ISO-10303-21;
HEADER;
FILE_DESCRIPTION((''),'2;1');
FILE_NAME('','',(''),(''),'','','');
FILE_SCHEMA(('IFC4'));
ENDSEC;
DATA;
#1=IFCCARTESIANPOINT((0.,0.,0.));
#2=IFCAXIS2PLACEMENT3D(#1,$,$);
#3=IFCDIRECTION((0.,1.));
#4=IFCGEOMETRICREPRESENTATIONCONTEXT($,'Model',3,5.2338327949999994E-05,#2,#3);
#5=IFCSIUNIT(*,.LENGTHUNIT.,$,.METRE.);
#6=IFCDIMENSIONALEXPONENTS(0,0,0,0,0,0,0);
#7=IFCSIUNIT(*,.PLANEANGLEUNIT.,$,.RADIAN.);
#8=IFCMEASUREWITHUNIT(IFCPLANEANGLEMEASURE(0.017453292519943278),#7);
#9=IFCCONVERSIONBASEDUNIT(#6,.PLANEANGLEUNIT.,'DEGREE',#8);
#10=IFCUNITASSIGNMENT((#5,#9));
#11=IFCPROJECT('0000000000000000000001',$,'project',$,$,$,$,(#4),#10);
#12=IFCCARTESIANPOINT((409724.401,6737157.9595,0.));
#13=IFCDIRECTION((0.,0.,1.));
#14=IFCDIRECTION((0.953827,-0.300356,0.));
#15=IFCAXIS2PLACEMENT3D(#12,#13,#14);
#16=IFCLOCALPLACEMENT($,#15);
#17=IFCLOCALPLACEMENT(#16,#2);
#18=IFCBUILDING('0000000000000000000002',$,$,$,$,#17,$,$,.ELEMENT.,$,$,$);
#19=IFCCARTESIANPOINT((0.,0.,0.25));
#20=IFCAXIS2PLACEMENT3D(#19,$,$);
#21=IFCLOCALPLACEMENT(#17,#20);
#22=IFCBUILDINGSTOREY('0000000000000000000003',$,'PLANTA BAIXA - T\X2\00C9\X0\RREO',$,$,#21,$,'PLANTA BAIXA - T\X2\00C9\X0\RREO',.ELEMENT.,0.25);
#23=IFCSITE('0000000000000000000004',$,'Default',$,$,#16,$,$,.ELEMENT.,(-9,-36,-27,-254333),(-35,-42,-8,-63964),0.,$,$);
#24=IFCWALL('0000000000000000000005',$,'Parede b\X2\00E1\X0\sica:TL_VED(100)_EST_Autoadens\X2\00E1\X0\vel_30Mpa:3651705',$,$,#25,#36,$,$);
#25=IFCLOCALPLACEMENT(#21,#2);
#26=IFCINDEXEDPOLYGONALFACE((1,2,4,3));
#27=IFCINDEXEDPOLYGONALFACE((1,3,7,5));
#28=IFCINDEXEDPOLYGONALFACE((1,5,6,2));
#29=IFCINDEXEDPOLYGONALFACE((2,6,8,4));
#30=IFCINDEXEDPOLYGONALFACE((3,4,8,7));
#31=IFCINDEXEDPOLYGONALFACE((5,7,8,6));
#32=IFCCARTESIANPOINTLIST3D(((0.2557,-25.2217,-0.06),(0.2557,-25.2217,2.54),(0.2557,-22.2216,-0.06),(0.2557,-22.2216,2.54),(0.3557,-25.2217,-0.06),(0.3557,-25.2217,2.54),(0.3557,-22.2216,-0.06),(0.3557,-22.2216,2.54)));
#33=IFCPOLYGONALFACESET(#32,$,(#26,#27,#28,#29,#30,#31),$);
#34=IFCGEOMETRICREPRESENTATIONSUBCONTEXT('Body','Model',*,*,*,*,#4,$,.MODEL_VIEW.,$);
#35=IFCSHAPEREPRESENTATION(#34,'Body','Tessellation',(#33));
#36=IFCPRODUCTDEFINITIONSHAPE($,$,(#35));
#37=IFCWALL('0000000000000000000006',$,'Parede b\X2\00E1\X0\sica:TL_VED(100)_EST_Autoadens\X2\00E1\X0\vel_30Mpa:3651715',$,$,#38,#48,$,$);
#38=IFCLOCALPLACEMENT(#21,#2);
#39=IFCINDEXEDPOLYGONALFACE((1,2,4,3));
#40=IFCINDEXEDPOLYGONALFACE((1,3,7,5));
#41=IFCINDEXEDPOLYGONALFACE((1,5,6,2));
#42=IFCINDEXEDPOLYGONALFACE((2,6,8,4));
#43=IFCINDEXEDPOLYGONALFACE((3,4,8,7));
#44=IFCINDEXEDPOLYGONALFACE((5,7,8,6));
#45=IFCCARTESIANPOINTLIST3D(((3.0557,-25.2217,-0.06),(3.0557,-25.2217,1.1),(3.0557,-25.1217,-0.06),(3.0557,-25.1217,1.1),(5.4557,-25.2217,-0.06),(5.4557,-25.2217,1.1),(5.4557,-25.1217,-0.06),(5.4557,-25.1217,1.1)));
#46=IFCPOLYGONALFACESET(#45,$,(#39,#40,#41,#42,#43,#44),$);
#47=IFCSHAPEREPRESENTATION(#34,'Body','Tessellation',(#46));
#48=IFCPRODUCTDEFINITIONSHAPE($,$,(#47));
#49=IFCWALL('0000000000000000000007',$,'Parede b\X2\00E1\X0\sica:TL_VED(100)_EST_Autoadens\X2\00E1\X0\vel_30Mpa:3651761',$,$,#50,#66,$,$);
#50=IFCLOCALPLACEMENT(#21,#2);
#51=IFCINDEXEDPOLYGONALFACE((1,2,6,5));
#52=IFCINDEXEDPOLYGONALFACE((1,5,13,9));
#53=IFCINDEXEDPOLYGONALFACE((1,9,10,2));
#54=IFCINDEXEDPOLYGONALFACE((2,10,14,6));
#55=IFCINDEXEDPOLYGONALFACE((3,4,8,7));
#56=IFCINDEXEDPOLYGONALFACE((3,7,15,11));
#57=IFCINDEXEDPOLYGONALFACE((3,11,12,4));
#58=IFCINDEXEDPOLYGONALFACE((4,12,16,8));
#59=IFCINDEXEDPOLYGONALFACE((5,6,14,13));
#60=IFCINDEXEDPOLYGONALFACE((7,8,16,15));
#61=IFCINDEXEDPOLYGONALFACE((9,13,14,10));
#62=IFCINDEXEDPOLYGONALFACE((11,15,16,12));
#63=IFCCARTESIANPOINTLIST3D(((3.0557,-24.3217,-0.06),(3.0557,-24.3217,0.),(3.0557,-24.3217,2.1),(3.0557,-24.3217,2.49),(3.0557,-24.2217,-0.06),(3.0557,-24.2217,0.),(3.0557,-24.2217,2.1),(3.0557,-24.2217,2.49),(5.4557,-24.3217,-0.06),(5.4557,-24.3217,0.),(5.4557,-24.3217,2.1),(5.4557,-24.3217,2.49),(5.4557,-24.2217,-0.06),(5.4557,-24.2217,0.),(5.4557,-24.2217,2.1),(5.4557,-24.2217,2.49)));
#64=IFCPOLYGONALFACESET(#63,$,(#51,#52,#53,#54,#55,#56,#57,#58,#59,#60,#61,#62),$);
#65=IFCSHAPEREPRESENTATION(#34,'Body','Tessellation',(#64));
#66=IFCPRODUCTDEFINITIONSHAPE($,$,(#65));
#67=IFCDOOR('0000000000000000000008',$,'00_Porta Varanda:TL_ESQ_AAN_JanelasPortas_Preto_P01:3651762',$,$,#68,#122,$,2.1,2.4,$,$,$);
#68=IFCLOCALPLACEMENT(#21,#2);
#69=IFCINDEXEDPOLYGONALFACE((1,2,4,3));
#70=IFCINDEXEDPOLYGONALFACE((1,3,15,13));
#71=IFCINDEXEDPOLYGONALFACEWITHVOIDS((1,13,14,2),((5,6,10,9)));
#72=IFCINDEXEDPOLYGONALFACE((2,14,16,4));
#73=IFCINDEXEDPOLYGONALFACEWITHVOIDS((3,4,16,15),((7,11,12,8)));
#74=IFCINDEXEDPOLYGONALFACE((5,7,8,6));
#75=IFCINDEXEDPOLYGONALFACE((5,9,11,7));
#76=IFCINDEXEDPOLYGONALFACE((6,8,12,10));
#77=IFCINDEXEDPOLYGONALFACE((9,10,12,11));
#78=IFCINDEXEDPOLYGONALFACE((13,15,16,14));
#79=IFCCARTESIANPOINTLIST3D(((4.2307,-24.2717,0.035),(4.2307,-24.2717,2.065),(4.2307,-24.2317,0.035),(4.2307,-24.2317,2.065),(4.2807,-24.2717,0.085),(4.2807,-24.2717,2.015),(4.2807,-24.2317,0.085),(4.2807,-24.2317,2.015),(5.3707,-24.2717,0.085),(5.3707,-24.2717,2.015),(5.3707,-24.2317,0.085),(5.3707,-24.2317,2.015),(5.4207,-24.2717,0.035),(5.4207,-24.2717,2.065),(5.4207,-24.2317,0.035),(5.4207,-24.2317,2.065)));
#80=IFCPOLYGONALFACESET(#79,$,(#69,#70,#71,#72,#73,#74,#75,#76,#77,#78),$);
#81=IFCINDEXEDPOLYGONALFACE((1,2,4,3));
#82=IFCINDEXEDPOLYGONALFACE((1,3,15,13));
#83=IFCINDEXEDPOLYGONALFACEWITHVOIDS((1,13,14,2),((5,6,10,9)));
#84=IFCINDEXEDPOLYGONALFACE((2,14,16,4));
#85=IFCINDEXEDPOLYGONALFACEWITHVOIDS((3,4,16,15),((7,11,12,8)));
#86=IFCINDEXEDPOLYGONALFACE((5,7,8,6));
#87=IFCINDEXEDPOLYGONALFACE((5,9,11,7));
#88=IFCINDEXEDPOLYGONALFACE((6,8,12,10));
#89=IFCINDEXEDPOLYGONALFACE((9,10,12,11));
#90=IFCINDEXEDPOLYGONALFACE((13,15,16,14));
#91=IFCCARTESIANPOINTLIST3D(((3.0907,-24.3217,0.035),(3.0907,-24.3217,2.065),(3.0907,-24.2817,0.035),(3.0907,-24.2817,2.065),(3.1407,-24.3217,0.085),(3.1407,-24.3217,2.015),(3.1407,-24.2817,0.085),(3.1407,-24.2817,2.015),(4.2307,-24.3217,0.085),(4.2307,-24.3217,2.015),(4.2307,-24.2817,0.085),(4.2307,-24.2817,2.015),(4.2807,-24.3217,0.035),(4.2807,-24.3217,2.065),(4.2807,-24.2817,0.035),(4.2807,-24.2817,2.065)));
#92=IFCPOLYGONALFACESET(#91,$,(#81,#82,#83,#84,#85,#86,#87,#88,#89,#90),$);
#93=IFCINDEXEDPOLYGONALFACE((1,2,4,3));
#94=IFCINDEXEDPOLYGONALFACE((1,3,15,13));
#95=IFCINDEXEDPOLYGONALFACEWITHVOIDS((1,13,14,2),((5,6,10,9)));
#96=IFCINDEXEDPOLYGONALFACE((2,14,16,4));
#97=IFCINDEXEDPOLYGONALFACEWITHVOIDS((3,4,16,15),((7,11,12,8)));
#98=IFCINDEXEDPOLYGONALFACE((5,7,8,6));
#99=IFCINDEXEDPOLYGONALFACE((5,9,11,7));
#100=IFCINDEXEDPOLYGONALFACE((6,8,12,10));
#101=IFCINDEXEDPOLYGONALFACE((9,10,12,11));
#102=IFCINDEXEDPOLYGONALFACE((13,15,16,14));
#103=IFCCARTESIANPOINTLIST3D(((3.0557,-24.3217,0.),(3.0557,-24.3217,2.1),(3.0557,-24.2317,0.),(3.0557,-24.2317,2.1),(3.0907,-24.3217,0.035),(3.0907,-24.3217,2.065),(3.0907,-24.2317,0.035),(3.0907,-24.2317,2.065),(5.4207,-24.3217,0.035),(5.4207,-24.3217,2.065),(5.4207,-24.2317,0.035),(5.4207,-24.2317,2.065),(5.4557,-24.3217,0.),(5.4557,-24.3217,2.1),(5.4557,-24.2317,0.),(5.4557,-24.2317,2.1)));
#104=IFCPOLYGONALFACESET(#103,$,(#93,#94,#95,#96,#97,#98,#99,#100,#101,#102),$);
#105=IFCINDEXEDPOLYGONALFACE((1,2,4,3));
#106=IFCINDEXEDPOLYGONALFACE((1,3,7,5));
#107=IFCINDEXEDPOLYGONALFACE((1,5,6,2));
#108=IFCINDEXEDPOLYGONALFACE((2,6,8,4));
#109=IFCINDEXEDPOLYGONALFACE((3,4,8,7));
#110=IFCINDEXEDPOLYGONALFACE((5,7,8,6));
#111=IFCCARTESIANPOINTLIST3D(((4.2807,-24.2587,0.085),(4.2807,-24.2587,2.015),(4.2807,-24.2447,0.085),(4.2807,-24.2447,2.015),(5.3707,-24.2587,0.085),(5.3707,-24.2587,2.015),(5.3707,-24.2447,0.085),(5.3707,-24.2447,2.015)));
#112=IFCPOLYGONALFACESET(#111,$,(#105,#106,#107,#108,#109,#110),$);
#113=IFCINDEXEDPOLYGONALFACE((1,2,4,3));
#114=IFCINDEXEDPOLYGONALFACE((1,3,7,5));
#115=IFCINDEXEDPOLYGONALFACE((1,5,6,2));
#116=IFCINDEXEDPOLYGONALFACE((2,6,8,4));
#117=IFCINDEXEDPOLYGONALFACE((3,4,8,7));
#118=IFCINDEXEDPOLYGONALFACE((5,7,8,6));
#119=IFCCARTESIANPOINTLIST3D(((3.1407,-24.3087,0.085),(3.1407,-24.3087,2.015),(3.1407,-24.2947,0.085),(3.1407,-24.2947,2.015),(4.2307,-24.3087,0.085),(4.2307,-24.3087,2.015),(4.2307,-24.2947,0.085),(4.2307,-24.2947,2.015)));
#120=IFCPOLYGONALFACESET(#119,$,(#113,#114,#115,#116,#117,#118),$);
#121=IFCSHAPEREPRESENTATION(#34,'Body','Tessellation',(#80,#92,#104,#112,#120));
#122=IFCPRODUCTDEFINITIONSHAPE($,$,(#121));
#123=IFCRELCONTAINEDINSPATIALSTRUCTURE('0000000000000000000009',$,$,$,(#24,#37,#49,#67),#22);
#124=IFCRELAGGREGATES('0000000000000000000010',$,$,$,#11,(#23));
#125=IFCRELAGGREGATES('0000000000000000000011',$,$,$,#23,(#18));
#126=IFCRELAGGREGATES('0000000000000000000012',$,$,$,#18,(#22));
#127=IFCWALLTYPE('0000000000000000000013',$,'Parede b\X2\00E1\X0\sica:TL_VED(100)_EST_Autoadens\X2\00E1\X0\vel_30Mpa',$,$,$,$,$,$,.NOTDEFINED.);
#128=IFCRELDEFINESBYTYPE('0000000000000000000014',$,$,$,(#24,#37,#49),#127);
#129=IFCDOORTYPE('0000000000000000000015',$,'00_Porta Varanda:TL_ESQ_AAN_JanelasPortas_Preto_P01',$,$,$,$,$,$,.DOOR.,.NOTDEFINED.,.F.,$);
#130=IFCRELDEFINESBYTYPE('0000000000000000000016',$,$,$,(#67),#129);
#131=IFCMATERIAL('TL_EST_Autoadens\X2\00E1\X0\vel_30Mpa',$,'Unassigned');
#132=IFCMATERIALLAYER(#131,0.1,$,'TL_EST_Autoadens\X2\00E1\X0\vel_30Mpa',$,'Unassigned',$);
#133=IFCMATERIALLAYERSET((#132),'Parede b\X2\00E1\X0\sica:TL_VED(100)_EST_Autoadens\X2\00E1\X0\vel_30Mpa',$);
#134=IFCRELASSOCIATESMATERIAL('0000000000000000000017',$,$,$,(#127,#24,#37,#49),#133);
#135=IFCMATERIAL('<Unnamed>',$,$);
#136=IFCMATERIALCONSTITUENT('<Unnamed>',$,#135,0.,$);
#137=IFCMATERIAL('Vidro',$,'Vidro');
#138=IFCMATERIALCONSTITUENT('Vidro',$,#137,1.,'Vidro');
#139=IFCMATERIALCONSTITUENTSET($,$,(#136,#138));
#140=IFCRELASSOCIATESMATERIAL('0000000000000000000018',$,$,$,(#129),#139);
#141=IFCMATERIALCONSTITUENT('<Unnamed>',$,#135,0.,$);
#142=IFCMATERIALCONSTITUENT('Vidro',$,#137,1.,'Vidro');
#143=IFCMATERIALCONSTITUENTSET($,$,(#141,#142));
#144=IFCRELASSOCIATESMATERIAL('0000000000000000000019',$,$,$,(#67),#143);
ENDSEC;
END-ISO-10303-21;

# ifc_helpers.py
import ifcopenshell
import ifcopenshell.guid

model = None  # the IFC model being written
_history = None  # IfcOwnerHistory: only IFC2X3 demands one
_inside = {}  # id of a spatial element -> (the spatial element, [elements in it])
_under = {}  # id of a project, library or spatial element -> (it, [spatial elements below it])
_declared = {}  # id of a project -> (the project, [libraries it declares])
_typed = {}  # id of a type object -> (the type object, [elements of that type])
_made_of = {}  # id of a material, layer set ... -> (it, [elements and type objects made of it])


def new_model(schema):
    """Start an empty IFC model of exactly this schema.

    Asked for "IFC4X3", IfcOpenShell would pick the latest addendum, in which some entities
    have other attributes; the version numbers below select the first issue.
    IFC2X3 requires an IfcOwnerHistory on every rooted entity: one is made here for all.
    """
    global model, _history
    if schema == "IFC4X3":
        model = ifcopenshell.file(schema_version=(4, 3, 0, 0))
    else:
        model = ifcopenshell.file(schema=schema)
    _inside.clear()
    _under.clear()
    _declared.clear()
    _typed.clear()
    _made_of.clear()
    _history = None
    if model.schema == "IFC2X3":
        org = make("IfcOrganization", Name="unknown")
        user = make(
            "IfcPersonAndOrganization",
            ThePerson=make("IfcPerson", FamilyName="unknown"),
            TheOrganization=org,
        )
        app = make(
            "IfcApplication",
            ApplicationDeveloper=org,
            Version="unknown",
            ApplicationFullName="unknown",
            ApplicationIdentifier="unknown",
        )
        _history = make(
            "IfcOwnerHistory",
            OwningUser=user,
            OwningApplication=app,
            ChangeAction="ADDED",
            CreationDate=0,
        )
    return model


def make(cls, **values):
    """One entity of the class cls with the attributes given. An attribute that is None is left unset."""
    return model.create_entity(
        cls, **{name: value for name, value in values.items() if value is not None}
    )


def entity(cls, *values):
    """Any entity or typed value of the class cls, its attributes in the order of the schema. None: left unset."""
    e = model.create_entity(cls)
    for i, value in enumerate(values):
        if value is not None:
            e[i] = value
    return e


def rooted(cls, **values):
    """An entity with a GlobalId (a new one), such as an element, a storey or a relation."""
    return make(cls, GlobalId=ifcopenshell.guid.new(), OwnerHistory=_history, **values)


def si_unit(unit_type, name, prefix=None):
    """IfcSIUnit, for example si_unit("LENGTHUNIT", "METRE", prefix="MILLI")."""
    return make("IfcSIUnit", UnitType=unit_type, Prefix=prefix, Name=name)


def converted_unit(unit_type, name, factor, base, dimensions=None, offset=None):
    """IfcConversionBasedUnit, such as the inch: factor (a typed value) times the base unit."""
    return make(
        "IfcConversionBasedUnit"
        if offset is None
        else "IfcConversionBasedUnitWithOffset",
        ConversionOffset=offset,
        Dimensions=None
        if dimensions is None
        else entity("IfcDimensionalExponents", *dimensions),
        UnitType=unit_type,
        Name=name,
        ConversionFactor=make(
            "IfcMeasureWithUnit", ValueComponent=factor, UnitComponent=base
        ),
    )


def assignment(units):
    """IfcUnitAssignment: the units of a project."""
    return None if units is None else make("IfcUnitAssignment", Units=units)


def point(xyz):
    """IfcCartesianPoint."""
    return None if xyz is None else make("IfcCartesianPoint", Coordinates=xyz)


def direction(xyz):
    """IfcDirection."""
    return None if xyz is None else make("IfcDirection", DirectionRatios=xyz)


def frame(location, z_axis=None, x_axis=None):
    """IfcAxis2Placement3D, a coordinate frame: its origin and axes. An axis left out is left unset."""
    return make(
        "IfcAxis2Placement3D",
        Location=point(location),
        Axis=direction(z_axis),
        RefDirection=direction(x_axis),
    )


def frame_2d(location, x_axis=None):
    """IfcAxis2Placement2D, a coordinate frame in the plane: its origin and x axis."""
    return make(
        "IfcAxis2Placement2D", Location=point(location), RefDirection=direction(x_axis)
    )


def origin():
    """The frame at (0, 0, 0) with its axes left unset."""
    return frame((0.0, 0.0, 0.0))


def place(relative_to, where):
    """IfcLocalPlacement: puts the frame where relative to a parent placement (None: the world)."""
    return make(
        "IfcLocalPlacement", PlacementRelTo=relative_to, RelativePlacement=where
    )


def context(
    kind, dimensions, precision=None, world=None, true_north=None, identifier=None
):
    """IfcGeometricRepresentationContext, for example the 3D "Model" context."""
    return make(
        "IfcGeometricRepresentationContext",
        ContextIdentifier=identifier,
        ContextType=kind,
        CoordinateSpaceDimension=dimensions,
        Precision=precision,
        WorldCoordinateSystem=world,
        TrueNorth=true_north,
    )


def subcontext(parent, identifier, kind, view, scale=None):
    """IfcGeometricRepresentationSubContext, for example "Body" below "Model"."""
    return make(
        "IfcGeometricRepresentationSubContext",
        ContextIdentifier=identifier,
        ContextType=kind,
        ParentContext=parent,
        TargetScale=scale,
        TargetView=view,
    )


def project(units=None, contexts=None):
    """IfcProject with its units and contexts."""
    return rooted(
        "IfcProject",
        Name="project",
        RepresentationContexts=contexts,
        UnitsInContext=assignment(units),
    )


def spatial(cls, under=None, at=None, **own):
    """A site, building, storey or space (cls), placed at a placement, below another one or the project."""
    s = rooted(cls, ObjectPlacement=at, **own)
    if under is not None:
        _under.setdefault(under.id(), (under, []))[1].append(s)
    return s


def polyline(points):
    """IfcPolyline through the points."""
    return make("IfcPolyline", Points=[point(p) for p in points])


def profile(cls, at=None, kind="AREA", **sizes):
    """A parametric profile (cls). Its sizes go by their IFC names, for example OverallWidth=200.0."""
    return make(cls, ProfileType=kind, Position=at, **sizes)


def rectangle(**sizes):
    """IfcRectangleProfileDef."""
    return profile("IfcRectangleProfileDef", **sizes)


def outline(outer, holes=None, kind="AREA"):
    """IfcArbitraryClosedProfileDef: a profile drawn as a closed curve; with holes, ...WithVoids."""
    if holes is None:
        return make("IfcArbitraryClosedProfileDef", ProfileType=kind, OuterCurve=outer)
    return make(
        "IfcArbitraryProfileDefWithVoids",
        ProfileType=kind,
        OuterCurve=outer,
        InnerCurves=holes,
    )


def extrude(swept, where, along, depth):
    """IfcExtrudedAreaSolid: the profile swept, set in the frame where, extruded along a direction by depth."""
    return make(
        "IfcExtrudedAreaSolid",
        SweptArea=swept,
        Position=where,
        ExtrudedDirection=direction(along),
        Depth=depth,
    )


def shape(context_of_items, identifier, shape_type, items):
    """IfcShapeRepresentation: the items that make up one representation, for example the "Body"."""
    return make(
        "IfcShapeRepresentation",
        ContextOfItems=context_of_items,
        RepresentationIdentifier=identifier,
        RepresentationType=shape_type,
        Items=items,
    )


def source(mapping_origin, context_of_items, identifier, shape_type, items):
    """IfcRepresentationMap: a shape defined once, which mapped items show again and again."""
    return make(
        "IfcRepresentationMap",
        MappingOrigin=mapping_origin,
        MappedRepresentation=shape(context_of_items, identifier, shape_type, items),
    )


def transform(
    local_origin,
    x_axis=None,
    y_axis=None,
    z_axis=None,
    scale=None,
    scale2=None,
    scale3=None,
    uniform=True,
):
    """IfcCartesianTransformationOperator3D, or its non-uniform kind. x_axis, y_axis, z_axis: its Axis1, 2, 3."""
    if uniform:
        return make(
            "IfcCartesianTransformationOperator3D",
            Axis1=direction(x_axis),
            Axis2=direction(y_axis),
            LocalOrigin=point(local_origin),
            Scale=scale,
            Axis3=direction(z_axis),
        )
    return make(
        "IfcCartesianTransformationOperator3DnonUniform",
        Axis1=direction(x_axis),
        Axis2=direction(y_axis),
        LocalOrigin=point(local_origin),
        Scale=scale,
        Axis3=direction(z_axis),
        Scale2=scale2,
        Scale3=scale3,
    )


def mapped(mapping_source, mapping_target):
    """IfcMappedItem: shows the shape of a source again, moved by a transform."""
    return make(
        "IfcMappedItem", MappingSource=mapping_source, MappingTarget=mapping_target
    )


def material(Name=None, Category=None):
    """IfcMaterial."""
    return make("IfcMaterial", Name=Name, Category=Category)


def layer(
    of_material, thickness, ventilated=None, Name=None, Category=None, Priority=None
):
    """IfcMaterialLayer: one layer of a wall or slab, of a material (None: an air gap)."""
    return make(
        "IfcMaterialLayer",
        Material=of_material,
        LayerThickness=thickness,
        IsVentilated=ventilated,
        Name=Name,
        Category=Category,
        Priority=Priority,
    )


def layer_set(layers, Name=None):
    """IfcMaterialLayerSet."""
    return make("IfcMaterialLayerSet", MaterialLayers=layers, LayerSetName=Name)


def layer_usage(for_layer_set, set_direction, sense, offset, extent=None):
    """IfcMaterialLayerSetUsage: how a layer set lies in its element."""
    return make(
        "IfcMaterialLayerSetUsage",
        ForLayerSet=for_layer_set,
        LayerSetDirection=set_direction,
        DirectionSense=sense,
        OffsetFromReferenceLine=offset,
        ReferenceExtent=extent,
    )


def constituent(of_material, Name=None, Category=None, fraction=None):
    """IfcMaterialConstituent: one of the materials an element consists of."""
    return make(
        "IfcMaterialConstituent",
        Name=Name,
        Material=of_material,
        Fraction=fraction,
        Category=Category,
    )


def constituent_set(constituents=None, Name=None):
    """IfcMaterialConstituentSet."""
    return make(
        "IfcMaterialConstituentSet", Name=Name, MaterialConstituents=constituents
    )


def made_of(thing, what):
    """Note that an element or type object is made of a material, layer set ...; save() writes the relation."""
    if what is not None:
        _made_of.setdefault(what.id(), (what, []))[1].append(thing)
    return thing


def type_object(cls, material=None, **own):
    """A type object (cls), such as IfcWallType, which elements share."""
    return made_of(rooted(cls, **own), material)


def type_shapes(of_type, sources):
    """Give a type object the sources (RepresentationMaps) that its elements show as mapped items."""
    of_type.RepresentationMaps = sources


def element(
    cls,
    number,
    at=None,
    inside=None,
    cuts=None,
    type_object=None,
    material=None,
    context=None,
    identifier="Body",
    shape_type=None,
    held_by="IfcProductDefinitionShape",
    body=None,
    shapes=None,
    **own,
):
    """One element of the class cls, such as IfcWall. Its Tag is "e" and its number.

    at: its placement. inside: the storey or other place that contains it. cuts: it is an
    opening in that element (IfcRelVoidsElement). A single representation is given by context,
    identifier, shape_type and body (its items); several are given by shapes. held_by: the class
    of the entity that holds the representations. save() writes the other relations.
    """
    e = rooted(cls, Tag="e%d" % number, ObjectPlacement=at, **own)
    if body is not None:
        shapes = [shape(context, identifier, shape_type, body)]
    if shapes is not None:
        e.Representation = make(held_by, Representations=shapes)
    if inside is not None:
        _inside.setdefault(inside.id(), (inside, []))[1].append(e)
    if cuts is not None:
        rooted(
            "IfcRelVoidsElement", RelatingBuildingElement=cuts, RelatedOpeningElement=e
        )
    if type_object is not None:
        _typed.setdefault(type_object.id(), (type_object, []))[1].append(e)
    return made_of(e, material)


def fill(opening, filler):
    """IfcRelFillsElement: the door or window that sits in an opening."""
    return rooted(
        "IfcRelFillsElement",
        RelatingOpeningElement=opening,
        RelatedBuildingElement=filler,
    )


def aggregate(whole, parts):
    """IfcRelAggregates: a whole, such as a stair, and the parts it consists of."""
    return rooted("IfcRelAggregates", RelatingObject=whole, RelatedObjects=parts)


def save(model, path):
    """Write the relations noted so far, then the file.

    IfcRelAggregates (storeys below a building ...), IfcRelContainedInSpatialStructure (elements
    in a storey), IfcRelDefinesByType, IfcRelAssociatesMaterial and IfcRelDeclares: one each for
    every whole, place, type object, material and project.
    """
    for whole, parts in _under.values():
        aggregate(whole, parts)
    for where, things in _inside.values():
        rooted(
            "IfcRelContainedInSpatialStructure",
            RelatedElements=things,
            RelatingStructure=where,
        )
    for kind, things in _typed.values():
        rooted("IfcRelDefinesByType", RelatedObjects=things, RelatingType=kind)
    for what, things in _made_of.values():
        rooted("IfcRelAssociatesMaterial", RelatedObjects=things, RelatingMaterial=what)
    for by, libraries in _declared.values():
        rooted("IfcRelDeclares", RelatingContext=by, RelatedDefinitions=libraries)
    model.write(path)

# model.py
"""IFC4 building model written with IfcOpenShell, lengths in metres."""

from ifc_helpers import new_model, entity, si_unit, converted_unit, direction, frame, frame_2d, origin, place, context, subcontext, project, spatial, polyline, rectangle, outline, extrude, source, transform, mapped, material, layer, layer_set, layer_usage, constituent, constituent_set, type_object, type_shapes, element, fill, save


model = new_model("IFC4")

# Units and contexts
model_context = context("Model", 3, precision=5.2338327949999994e-05, world=origin(), true_north=direction((0.0, 1.0)))
body_context = subcontext(model_context, "Body", "Model", "MODEL_VIEW")
ifc_project = project(units=[si_unit("LENGTHUNIT", "METRE"), converted_unit("PLANEANGLEUNIT", "DEGREE", entity("IfcPlaneAngleMeasure", 0.017453292519943278), si_unit("PLANEANGLEUNIT", "RADIAN"), dimensions=[0, 0, 0, 0, 0, 0, 0])], contexts=[model_context])

# Site, building, storey
site_placement = place(None, frame((409724.401, 6737157.9595, 0.0), z_axis=(0.0, 0.0, 1.0), x_axis=(0.953827, -0.300356, 0.0)))
site = spatial("IfcSite", under=ifc_project, at=site_placement, Name="Default", CompositionType="ELEMENT", RefLatitude=(-9, -36, -27, -254333), RefLongitude=(-35, -42, -8, -63964), RefElevation=0.0)
building_placement = place(site_placement, origin())
building = spatial("IfcBuilding", under=site, at=building_placement, CompositionType="ELEMENT")
storey_placement = place(building_placement, frame((0.0, 0.0, 0.25)))
storey = spatial("IfcBuildingStorey", under=building, at=storey_placement, Name="PLANTA BAIXA - TÉRREO", LongName="PLANTA BAIXA - TÉRREO", CompositionType="ELEMENT", Elevation=0.25)

# Wall
ifc_material_1 = material(Name="TL_EST_Autoadensável_30Mpa", Category="Unassigned")
ifc_layer_1 = layer(ifc_material_1, 0.1, Name="TL_EST_Autoadensável_30Mpa", Category="Unassigned")
ifc_layer_set_1 = layer_set([ifc_layer_1], Name="Parede básica:TL_VED(100)_EST_Autoadensável_30Mpa")
ifc_layer_usage_1 = layer_usage(ifc_layer_set_1, "AXIS2", "POSITIVE", -0.05)
wall_type_1 = type_object("IfcWallType", Name="Parede básica:TL_VED(100)_EST_Autoadensável_30Mpa", PredefinedType="NOTDEFINED", material=ifc_layer_set_1)
wall_1_placement = place(storey_placement, frame((0.3057, -25.2217, -0.06), z_axis=(0.0, 0.0, 1.0), x_axis=(0.0, 1.0, 0.0)))
element("IfcWall", 1, at=wall_1_placement, inside=storey, type_object=wall_type_1, material=ifc_layer_usage_1, Name="Parede básica:TL_VED(100)_EST_Autoadensável_30Mpa:3651705", context=body_context, shape_type="SweptSolid", body=[
    extrude(rectangle(XDim=3.0001, YDim=0.1, at=frame_2d((1.5001, 0.0), x_axis=(-1.0, 0.0))), origin(), (0.0, 0.0, 1.0), 2.6),
])

# Wall
ifc_layer_usage_2 = layer_usage(ifc_layer_set_1, "AXIS2", "POSITIVE", -0.05)
wall_2_placement = place(storey_placement, frame((3.0557, -25.1717, -0.06)))
element("IfcWall", 2, at=wall_2_placement, inside=storey, type_object=wall_type_1, material=ifc_layer_usage_2, Name="Parede básica:TL_VED(100)_EST_Autoadensável_30Mpa:3651715", context=body_context, shape_type="SweptSolid", body=[
    extrude(rectangle(XDim=2.4, YDim=0.1, at=frame_2d((1.2, 0.0), x_axis=(-1.0, 0.0))), origin(), (0.0, 0.0, 1.0), 1.16),
])

# Wall, opening, door
ifc_layer_usage_3 = layer_usage(ifc_layer_set_1, "AXIS2", "POSITIVE", -0.05)
wall_3_placement = place(storey_placement, frame((3.0557, -24.2717, -0.06)))
wall_3 = element("IfcWall", 3, at=wall_3_placement, inside=storey, type_object=wall_type_1, material=ifc_layer_usage_3, Name="Parede básica:TL_VED(100)_EST_Autoadensável_30Mpa:3651761", context=body_context, shape_type="SweptSolid", body=[
    extrude(rectangle(XDim=2.4, YDim=0.1, at=frame_2d((1.2, 0.0), x_axis=(-1.0, 0.0))), origin(), (0.0, 0.0, 1.0), 2.55),
])
opening_1_placement = place(wall_3_placement, frame((0.0, -0.05, 0.06)))
opening_1 = element("IfcOpeningElement", 4, at=opening_1_placement, cuts=wall_3, PredefinedType="OPENING", context=body_context, shape_type="SweptSolid", body=[
    extrude(rectangle(XDim=2.1, YDim=2.4, at=frame_2d((1.05, 1.2), x_axis=(1.0, 0.0))), frame((0.0, 0.0, 0.0), z_axis=(0.0, 1.0, 0.0), x_axis=(0.0, 0.0, 1.0)), (0.0, 0.0, 1.0), 0.1),
])
ifc_material_2 = material(Name="<Unnamed>")
ifc_constituent_1 = constituent(ifc_material_2, Name="<Unnamed>", fraction=0.0)
ifc_material_3 = material(Name="Vidro", Category="Vidro")
ifc_constituent_2 = constituent(ifc_material_3, Name="Vidro", Category="Vidro", fraction=1.0)
ifc_constituent_set_1 = constituent_set(constituents=[ifc_constituent_1, ifc_constituent_2])
ifc_constituent_3 = constituent(ifc_material_2, Name="<Unnamed>", fraction=0.0)
ifc_constituent_4 = constituent(ifc_material_3, Name="Vidro", Category="Vidro", fraction=1.0)
ifc_constituent_set_2 = constituent_set(constituents=[ifc_constituent_3, ifc_constituent_4])
door_type = type_object("IfcDoorType", Name="00_Porta Varanda:TL_ESQ_AAN_JanelasPortas_Preto_P01", OperationType="NOTDEFINED", ParameterTakesPrecedence=False, PredefinedType="DOOR", material=ifc_constituent_set_2)
shared_shape_1 = source(origin(), body_context, "Body", "SweptSolid", [
    extrude(outline(polyline([(-1.015, -0.595), (1.015, -0.595), (1.015, 0.595), (-1.015, 0.595), (-1.015, -0.595)]), holes=[polyline([(0.965, -0.545), (-0.965, -0.545), (-0.965, 0.545), (0.965, 0.545), (0.965, -0.545)])]), frame((1.77, 0.05, 1.05), z_axis=(0.0, 1.0, 0.0), x_axis=(0.0, 0.0, 1.0)), (0.0, 0.0, 1.0), 0.04),
    extrude(outline(polyline([(-1.015, -0.595), (1.015, -0.595), (1.015, 0.595), (-1.015, 0.595), (-1.015, -0.595)]), holes=[polyline([(0.965, -0.545), (-0.965, -0.545), (-0.965, 0.545), (0.965, 0.545), (0.965, -0.545)])]), frame((0.63, 0.0, 1.05), z_axis=(0.0, 1.0, 0.0), x_axis=(0.0, 0.0, -1.0)), (0.0, 0.0, 1.0), 0.04),
    extrude(outline(polyline([(-1.05, -1.2), (1.05, -1.2), (1.05, 1.2), (-1.05, 1.2), (-1.05, -1.2)]), holes=[polyline([(1.015, -1.165), (-1.015, -1.165), (-1.015, 1.165), (1.015, 1.165), (1.015, -1.165)])]), frame((1.2, 0.0, 1.05), z_axis=(0.0, 1.0, 0.0), x_axis=(0.0, 0.0, -1.0)), (0.0, 0.0, 1.0), 0.09),
    extrude(rectangle(XDim=0.014, YDim=1.09, at=frame_2d((0.0, 0.0), x_axis=(1.0, 0.0))), frame((1.77, 0.07, 0.085), z_axis=(0.0, 0.0, 1.0), x_axis=(0.0, -1.0, 0.0)), (0.0, 0.0, 1.0), 1.93),
    extrude(rectangle(XDim=0.014, YDim=1.09, at=frame_2d((0.0, 0.0), x_axis=(1.0, 0.0))), frame((0.63, 0.02, 0.085), z_axis=(0.0, 0.0, 1.0), x_axis=(0.0, -1.0, 0.0)), (0.0, 0.0, 1.0), 1.93),
])
type_shapes(door_type, [shared_shape_1])
door_placement = place(opening_1_placement, origin())
door = element("IfcDoor", 5, at=door_placement, inside=storey, type_object=door_type, material=ifc_constituent_set_1, Name="00_Porta Varanda:TL_ESQ_AAN_JanelasPortas_Preto_P01:3651762", OverallHeight=2.1, OverallWidth=2.4, context=body_context, shape_type="MappedRepresentation", body=[
    mapped(shared_shape_1, transform((0.0, 0.0, 0.0), scale=1.0)),
])
fill(opening_1, door)

save(model, "model.ifc")
